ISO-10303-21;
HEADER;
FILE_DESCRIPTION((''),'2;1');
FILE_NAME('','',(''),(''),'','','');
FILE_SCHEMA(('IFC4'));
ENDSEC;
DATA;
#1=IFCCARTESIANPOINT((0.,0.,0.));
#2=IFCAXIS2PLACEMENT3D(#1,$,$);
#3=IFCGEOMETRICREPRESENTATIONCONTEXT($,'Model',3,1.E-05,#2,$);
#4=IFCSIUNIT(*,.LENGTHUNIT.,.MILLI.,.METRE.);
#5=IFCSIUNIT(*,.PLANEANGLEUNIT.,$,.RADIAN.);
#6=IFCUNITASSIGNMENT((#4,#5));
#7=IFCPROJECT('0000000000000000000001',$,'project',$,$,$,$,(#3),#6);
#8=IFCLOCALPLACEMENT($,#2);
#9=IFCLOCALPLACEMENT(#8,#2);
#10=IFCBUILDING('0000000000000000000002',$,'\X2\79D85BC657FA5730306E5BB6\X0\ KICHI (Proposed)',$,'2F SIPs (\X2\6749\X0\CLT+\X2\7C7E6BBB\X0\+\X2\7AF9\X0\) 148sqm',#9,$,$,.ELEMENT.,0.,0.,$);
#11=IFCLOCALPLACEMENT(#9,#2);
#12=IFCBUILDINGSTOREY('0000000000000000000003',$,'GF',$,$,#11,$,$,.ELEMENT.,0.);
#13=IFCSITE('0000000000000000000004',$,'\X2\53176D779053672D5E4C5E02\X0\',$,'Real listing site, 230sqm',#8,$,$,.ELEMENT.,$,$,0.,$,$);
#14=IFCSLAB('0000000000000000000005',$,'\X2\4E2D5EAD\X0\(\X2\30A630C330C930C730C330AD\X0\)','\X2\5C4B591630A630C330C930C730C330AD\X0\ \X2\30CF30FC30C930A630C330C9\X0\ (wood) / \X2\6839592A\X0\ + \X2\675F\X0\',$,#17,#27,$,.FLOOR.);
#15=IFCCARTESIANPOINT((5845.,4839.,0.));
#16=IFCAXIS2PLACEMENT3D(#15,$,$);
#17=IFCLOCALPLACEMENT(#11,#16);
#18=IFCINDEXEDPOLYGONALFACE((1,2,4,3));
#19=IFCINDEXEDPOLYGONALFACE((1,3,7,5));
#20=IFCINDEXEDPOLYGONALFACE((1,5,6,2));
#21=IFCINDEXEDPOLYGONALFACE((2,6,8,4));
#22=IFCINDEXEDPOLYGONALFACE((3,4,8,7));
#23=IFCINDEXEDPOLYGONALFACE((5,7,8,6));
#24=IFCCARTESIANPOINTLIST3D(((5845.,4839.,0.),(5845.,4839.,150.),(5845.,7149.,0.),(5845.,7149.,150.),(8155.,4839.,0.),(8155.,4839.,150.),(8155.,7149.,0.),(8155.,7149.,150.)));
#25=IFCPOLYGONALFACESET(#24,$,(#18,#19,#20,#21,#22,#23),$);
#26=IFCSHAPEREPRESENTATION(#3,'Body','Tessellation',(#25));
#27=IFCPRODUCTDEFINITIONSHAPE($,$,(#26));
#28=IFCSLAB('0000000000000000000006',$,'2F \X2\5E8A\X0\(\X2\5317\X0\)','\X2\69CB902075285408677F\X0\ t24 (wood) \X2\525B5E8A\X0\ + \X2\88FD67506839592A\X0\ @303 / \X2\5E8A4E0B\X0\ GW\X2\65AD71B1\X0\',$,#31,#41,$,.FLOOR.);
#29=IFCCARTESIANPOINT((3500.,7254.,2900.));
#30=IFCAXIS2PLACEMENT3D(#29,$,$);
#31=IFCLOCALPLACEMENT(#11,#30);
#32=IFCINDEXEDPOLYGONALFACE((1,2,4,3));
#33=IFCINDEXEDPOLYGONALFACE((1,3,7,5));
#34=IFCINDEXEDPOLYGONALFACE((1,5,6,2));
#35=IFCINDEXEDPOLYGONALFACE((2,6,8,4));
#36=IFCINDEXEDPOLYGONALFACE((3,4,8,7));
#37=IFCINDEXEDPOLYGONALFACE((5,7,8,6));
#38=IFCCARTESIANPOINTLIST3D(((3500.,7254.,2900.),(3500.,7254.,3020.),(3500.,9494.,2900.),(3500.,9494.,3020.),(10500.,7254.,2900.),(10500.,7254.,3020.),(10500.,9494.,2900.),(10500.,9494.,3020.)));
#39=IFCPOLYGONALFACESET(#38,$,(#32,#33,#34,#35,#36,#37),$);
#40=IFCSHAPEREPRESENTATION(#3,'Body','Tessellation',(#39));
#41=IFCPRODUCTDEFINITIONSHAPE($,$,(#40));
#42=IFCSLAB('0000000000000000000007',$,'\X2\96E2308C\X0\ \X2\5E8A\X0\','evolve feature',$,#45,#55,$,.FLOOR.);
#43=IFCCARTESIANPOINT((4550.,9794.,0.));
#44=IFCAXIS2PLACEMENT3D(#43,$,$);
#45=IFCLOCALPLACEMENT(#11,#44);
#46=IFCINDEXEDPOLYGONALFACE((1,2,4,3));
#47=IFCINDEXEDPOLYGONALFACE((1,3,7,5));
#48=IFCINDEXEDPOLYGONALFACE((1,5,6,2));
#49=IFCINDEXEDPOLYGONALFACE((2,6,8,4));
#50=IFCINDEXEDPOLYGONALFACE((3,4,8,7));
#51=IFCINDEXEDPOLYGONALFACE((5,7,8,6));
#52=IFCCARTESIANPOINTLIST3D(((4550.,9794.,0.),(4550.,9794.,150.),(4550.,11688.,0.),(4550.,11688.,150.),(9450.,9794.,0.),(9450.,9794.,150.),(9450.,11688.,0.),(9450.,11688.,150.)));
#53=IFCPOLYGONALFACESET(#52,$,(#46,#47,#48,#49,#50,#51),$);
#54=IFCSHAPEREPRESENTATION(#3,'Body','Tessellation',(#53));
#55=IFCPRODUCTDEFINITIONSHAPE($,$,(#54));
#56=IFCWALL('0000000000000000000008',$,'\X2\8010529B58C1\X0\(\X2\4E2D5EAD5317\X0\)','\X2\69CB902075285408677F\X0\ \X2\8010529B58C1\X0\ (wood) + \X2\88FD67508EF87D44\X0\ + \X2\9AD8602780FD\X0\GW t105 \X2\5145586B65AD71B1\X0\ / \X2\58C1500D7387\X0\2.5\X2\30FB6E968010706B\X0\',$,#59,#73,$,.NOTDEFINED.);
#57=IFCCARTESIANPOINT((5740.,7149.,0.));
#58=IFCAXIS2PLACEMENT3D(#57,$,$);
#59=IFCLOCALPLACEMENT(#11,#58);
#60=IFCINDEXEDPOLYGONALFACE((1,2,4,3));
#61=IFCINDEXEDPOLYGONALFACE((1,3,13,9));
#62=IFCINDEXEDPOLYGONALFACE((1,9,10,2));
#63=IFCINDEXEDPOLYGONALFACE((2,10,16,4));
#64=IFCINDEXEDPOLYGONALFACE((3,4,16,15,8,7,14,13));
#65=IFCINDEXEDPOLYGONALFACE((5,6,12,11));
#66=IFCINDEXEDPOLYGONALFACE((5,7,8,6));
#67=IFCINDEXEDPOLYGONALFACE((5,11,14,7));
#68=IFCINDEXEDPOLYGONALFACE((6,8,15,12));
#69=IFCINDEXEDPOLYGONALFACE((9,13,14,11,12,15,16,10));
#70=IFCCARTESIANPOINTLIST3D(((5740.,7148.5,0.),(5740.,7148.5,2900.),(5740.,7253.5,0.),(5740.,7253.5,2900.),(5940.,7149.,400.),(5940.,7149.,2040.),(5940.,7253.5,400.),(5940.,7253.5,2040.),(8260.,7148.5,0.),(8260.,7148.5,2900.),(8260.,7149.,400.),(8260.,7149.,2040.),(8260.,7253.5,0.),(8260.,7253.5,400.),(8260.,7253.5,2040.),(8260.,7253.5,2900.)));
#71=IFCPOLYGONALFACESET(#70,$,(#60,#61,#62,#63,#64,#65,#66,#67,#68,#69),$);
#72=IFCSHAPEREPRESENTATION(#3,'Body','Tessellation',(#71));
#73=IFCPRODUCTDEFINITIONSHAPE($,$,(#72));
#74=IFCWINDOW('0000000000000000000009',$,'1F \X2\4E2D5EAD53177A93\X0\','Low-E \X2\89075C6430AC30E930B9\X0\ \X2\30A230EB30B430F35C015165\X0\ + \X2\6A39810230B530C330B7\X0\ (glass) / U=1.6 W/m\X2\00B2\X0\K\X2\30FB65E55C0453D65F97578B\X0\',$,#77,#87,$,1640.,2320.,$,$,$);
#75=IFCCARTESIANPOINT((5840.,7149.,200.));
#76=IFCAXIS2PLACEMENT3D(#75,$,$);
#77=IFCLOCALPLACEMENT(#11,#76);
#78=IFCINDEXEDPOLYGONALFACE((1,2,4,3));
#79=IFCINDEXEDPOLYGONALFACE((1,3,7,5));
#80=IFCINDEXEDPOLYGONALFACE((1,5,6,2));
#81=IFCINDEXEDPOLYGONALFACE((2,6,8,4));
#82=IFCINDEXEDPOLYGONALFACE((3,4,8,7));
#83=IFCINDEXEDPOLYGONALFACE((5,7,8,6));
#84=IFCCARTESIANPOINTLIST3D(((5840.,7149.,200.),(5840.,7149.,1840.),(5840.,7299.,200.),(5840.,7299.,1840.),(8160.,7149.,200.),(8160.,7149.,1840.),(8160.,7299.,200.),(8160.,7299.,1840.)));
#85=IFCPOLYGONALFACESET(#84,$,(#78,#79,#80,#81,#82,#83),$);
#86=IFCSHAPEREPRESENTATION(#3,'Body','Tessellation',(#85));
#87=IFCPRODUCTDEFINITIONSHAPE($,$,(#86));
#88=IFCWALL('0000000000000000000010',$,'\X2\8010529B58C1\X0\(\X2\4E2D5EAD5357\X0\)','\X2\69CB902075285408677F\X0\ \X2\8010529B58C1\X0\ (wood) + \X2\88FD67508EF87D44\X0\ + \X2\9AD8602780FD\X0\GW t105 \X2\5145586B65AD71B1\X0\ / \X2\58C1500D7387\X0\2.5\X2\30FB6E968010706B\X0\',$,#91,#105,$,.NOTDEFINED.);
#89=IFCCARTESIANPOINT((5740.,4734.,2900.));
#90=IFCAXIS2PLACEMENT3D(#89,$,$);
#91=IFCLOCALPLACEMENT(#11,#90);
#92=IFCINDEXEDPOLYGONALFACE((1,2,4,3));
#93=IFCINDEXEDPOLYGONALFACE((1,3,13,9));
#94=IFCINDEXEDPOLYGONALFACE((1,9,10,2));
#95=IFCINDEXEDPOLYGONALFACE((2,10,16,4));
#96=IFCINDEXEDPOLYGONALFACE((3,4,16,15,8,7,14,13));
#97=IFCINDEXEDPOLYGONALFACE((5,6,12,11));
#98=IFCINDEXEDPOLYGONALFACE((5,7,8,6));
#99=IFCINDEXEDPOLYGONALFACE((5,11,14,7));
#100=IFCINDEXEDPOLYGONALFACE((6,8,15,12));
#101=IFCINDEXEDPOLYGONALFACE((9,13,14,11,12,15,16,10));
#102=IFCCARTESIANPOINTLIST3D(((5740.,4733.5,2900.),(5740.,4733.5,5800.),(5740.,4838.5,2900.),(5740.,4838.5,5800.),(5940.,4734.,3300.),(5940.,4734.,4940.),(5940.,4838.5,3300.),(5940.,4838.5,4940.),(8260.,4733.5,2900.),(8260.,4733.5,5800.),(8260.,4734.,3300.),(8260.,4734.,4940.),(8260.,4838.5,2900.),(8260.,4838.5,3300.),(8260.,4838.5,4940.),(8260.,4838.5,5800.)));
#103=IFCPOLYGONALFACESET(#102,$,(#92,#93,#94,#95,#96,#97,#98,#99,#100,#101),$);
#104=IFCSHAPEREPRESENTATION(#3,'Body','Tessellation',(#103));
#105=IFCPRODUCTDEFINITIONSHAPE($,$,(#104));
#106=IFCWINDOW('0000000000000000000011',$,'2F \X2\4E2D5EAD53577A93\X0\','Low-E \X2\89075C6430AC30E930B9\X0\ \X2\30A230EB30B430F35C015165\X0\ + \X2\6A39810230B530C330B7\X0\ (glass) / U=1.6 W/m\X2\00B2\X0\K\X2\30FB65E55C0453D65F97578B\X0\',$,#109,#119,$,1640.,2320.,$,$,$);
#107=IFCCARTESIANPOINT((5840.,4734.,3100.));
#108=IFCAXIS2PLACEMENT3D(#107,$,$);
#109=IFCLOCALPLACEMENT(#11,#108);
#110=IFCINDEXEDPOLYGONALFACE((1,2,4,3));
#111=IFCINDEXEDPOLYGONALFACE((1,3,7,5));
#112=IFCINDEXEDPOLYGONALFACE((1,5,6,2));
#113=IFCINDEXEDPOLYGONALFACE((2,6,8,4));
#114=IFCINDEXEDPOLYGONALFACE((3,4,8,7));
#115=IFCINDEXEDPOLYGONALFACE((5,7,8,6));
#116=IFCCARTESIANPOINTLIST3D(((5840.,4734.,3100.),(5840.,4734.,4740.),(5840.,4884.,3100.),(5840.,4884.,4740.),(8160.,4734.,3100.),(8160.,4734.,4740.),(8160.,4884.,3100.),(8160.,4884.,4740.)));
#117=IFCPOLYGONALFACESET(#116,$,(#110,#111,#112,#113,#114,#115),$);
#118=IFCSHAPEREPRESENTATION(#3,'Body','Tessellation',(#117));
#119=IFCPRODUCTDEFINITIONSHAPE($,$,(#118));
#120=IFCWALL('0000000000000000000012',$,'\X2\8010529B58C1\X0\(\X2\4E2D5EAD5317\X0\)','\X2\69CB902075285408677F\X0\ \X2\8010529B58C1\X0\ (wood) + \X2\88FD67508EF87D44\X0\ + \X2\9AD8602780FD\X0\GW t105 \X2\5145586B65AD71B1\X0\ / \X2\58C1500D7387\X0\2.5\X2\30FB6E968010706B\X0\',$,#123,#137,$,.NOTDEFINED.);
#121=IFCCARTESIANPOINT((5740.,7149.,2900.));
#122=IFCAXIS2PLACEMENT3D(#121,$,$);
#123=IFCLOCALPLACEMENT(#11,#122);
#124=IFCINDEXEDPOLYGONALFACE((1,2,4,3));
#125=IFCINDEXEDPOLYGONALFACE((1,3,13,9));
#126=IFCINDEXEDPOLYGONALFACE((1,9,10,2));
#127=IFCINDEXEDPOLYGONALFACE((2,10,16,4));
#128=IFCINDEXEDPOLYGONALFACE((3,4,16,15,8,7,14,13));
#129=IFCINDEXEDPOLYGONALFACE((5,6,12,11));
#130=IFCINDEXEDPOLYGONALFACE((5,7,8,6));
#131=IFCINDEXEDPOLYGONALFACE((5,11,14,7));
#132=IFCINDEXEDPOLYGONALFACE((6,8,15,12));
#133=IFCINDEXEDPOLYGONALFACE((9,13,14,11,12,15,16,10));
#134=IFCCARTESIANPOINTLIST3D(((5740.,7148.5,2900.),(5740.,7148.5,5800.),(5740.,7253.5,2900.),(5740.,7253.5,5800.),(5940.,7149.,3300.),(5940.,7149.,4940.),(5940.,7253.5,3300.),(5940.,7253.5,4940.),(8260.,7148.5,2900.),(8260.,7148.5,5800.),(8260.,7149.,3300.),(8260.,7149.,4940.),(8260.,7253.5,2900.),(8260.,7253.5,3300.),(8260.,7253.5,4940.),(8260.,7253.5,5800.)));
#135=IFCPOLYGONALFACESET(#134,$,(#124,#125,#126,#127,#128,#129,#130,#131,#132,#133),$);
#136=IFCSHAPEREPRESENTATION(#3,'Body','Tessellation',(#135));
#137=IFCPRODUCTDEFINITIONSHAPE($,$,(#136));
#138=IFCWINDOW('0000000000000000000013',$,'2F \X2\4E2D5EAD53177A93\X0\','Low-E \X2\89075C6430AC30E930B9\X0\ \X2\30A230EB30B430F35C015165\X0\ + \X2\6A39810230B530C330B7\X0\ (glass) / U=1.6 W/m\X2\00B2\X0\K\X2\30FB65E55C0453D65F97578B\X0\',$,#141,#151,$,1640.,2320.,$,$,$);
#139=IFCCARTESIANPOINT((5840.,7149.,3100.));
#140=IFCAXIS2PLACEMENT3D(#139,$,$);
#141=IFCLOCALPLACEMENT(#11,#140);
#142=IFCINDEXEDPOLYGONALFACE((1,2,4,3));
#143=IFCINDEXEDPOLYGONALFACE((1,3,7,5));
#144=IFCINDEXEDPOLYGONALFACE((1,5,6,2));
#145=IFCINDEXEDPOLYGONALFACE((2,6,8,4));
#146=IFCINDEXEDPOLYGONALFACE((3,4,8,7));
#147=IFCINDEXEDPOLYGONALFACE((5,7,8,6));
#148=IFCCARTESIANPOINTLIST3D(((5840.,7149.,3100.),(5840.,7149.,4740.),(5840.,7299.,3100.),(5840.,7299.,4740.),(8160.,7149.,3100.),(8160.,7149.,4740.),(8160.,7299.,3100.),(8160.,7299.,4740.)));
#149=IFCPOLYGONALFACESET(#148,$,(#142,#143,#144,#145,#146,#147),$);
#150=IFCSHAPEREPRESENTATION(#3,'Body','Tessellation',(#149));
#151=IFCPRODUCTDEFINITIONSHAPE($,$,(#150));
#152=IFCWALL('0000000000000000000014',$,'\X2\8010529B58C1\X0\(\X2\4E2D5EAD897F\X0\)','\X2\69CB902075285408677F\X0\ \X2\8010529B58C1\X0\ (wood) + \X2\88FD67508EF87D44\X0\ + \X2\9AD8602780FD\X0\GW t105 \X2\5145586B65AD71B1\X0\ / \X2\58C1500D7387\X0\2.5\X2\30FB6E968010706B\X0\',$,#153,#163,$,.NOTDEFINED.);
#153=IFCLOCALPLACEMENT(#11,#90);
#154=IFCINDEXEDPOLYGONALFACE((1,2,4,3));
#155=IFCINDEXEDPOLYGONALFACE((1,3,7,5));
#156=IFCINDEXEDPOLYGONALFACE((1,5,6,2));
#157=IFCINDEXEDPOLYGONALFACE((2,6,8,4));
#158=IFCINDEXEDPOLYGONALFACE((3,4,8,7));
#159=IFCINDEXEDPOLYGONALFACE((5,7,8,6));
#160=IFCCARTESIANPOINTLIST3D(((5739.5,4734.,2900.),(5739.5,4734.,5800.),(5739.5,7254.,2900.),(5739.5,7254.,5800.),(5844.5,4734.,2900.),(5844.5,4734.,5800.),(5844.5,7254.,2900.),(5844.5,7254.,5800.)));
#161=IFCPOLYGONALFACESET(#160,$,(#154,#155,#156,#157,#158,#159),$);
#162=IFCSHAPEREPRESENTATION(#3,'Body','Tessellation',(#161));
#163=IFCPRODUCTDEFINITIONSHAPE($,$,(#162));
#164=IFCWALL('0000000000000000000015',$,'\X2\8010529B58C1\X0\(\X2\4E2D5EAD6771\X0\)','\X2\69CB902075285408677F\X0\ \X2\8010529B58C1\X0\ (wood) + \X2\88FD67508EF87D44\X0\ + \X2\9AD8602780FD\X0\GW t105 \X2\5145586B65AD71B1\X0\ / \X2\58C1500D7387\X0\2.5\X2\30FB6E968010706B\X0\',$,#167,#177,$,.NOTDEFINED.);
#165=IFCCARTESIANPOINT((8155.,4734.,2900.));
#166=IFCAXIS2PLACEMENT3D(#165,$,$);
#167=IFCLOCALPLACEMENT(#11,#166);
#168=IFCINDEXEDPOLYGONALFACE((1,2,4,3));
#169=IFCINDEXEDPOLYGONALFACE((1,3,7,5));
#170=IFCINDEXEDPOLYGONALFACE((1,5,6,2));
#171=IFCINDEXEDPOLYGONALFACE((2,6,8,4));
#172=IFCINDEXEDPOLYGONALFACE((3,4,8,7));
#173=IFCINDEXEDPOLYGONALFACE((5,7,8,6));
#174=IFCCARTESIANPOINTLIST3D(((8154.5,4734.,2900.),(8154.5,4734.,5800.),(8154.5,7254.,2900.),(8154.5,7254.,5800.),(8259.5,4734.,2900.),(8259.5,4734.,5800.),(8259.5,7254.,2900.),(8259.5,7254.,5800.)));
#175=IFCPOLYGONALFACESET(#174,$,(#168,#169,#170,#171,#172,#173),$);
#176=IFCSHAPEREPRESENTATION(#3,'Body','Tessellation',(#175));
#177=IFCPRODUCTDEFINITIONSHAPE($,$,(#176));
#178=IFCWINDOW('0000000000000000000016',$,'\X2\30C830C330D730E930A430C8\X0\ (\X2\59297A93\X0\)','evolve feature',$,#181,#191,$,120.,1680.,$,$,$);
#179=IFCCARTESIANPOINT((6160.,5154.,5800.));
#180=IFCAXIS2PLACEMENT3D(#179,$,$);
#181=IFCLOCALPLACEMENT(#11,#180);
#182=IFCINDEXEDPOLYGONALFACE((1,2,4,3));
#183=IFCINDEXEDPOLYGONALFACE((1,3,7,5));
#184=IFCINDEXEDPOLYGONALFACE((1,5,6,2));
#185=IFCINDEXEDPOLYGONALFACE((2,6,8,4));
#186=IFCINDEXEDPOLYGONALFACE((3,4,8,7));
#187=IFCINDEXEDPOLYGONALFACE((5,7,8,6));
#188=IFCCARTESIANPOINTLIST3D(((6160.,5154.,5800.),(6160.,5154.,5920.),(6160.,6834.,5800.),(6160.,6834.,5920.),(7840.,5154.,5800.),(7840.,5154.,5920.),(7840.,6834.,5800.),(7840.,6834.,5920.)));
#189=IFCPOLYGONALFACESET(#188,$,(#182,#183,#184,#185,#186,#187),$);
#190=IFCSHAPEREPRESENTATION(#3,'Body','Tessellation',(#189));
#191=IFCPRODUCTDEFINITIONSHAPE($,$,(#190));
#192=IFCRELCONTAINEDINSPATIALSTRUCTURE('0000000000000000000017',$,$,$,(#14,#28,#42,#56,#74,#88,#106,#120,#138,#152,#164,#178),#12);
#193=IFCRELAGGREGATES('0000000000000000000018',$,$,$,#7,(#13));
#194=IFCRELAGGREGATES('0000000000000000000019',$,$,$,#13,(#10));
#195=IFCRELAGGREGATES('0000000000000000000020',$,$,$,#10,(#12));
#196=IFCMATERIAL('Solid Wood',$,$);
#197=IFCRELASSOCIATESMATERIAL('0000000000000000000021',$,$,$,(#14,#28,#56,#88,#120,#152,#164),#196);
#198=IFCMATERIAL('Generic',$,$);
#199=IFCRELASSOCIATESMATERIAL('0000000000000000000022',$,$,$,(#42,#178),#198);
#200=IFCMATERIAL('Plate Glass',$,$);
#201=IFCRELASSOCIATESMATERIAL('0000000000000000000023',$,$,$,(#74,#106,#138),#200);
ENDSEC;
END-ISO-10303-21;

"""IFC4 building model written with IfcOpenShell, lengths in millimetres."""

from ifc_helpers import new_model, si_unit, frame, frame_2d, origin, place, context, project, spatial, rectangle, extrude, material, element, fill, save


model = new_model("IFC4")

# Units and contexts
model_context = context("Model", 3, precision=1e-05, world=origin())
ifc_project = project(units=[si_unit("LENGTHUNIT", "METRE", prefix="MILLI"), si_unit("PLANEANGLEUNIT", "RADIAN")], contexts=[model_context])

# Site, building, storey
site_placement = place(None, origin())
site = spatial("IfcSite", under=ifc_project, at=site_placement, Name="北海道札幌市", ObjectType="Real listing site, 230sqm", CompositionType="ELEMENT", RefElevation=0.0)
building_placement = place(site_placement, origin())
building = spatial("IfcBuilding", under=site, at=building_placement, Name="秘密基地の家 KICHI (Proposed)", ObjectType="2F SIPs (杉CLT+籾殻+竹) 148sqm", CompositionType="ELEMENT", ElevationOfRefHeight=0.0, ElevationOfTerrain=0.0)
storey_placement = place(building_placement, origin())
storey = spatial("IfcBuildingStorey", under=building, at=storey_placement, Name="GF", CompositionType="ELEMENT", Elevation=0.0)

# Slabs
ifc_material_1 = material(Name="Solid Wood")
slab_1_placement = place(storey_placement, frame((5845.0, 4839.0, 0.0)))
element("IfcSlab", 1, at=slab_1_placement, inside=storey, material=ifc_material_1, Name="中庭(ウッドデッキ)", Description="屋外ウッドデッキ ハードウッド (wood) / 根太 + 束", PredefinedType="FLOOR", context=model_context, shape_type="SweptSolid", body=[
    extrude(rectangle(XDim=2310.0, YDim=2310.0, at=frame_2d((1155.0, 1155.0))), frame((5845.0, 4839.0, 0.0)), (0.0, 0.0, 1.0), 150.0),
])
slab_2_placement = place(storey_placement, frame((3500.0, 7254.0, 2900.0)))
element("IfcSlab", 2, at=slab_2_placement, inside=storey, material=ifc_material_1, Name="2F 床(北)", Description="構造用合板 t24 (wood) 剛床 + 製材根太 @303 / 床下 GW断熱", PredefinedType="FLOOR", context=model_context, shape_type="SweptSolid", body=[
    extrude(rectangle(XDim=7000.0, YDim=2240.0, at=frame_2d((3500.0, 1120.0))), frame((3500.0, 7254.0, 2900.0)), (0.0, 0.0, 1.0), 120.0),
])
ifc_material_2 = material(Name="Generic")
slab_3_placement = place(storey_placement, frame((4550.0, 9794.0, 0.0)))
element("IfcSlab", 3, at=slab_3_placement, inside=storey, material=ifc_material_2, Name="離れ 床", Description="evolve feature", PredefinedType="FLOOR", context=model_context, shape_type="SweptSolid", body=[
    extrude(rectangle(XDim=4900.0, YDim=1894.0, at=frame_2d((2450.0, 947.0))), frame((4550.0, 9794.0, 0.0)), (0.0, 0.0, 1.0), 150.0),
])

# Wall, opening, window
wall_1_placement = place(storey_placement, frame((5740.0, 7149.0, 0.0)))
wall_1 = element("IfcWall", 4, at=wall_1_placement, inside=storey, material=ifc_material_1, Name="耐力壁(中庭北)", Description="構造用合板 耐力壁 (wood) + 製材軸組 + 高性能GW t105 充填断熱 / 壁倍率2.5・準耐火", PredefinedType="NOTDEFINED", context=model_context, shape_type="SweptSolid", body=[
    extrude(rectangle(XDim=2520.0, YDim=105.0, at=frame_2d((1260.0, 52.0))), frame((5740.0, 7149.0, 0.0)), (0.0, 0.0, 1.0), 2900.0),
])
opening_1_placement = place(storey_placement, frame((5840.0, 7149.0, 200.0)))
opening_1 = element("IfcOpeningElement", 5, at=opening_1_placement, cuts=wall_1, PredefinedType="NOTDEFINED", context=model_context, shape_type="SweptSolid", body=[
    extrude(rectangle(XDim=2320.0, YDim=150.0, at=frame_2d((1160.0, 75.0))), frame((5840.0, 7149.0, 200.0)), (0.0, 0.0, 1.0), 1640.0),
])
ifc_material_3 = material(Name="Plate Glass")
window_1_placement = place(storey_placement, frame((5840.0, 7149.0, 200.0)))
window_1 = element("IfcWindow", 6, at=window_1_placement, inside=storey, material=ifc_material_3, Name="1F 中庭北窓", Description="Low-E 複層ガラス アルゴン封入 + 樹脂サッシ (glass) / U=1.6 W/m²K・日射取得型", OverallHeight=1640.0, OverallWidth=2320.0, context=model_context, shape_type="SweptSolid", body=[
    extrude(rectangle(XDim=2320.0, YDim=150.0, at=frame_2d((1160.0, 75.0))), frame((5840.0, 7149.0, 200.0)), (0.0, 0.0, 1.0), 1640.0),
])
fill(opening_1, window_1)

# Walls, openings, windows
wall_2_placement = place(storey_placement, frame((5740.0, 4734.0, 2900.0)))
wall_2 = element("IfcWall", 7, at=wall_2_placement, inside=storey, material=ifc_material_1, Name="耐力壁(中庭南)", Description="構造用合板 耐力壁 (wood) + 製材軸組 + 高性能GW t105 充填断熱 / 壁倍率2.5・準耐火", PredefinedType="NOTDEFINED", context=model_context, shape_type="SweptSolid", body=[
    extrude(rectangle(XDim=2520.0, YDim=105.0, at=frame_2d((1260.0, 52.0))), frame((5740.0, 4734.0, 2900.0)), (0.0, 0.0, 1.0), 2900.0),
])
opening_2_placement = place(storey_placement, frame((5840.0, 4734.0, 3100.0)))
opening_2 = element("IfcOpeningElement", 8, at=opening_2_placement, cuts=wall_2, PredefinedType="NOTDEFINED", context=model_context, shape_type="SweptSolid", body=[
    extrude(rectangle(XDim=2320.0, YDim=150.0, at=frame_2d((1160.0, 75.0))), frame((5840.0, 4734.0, 3100.0)), (0.0, 0.0, 1.0), 1640.0),
])
window_2_placement = place(storey_placement, frame((5840.0, 4734.0, 3100.0)))
window_2 = element("IfcWindow", 9, at=window_2_placement, inside=storey, material=ifc_material_3, Name="2F 中庭南窓", Description="Low-E 複層ガラス アルゴン封入 + 樹脂サッシ (glass) / U=1.6 W/m²K・日射取得型", OverallHeight=1640.0, OverallWidth=2320.0, context=model_context, shape_type="SweptSolid", body=[
    extrude(rectangle(XDim=2320.0, YDim=150.0, at=frame_2d((1160.0, 75.0))), frame((5840.0, 4734.0, 3100.0)), (0.0, 0.0, 1.0), 1640.0),
])
fill(opening_2, window_2)
wall_3_placement = place(storey_placement, frame((5740.0, 7149.0, 2900.0)))
wall_3 = element("IfcWall", 10, at=wall_3_placement, inside=storey, material=ifc_material_1, Name="耐力壁(中庭北)", Description="構造用合板 耐力壁 (wood) + 製材軸組 + 高性能GW t105 充填断熱 / 壁倍率2.5・準耐火", PredefinedType="NOTDEFINED", context=model_context, shape_type="SweptSolid", body=[
    extrude(rectangle(XDim=2520.0, YDim=105.0, at=frame_2d((1260.0, 52.0))), frame((5740.0, 7149.0, 2900.0)), (0.0, 0.0, 1.0), 2900.0),
])
opening_3_placement = place(storey_placement, frame((5840.0, 7149.0, 3100.0)))
opening_3 = element("IfcOpeningElement", 11, at=opening_3_placement, cuts=wall_3, PredefinedType="NOTDEFINED", context=model_context, shape_type="SweptSolid", body=[
    extrude(rectangle(XDim=2320.0, YDim=150.0, at=frame_2d((1160.0, 75.0))), frame((5840.0, 7149.0, 3100.0)), (0.0, 0.0, 1.0), 1640.0),
])
window_3_placement = place(storey_placement, frame((5840.0, 7149.0, 3100.0)))
window_3 = element("IfcWindow", 12, at=window_3_placement, inside=storey, material=ifc_material_3, Name="2F 中庭北窓", Description="Low-E 複層ガラス アルゴン封入 + 樹脂サッシ (glass) / U=1.6 W/m²K・日射取得型", OverallHeight=1640.0, OverallWidth=2320.0, context=model_context, shape_type="SweptSolid", body=[
    extrude(rectangle(XDim=2320.0, YDim=150.0, at=frame_2d((1160.0, 75.0))), frame((5840.0, 7149.0, 3100.0)), (0.0, 0.0, 1.0), 1640.0),
])
fill(opening_3, window_3)

# Walls
wall_4_placement = place(storey_placement, frame((5740.0, 4734.0, 2900.0)))
element("IfcWall", 13, at=wall_4_placement, inside=storey, material=ifc_material_1, Name="耐力壁(中庭西)", Description="構造用合板 耐力壁 (wood) + 製材軸組 + 高性能GW t105 充填断熱 / 壁倍率2.5・準耐火", PredefinedType="NOTDEFINED", context=model_context, shape_type="SweptSolid", body=[
    extrude(rectangle(XDim=105.0, YDim=2520.0, at=frame_2d((52.0, 1260.0))), frame((5740.0, 4734.0, 2900.0)), (0.0, 0.0, 1.0), 2900.0),
])
wall_5_placement = place(storey_placement, frame((8155.0, 4734.0, 2900.0)))
element("IfcWall", 14, at=wall_5_placement, inside=storey, material=ifc_material_1, Name="耐力壁(中庭東)", Description="構造用合板 耐力壁 (wood) + 製材軸組 + 高性能GW t105 充填断熱 / 壁倍率2.5・準耐火", PredefinedType="NOTDEFINED", context=model_context, shape_type="SweptSolid", body=[
    extrude(rectangle(XDim=105.0, YDim=2520.0, at=frame_2d((52.0, 1260.0))), frame((8155.0, 4734.0, 2900.0)), (0.0, 0.0, 1.0), 2900.0),
])

# Window
window_4_placement = place(storey_placement, frame((6160.0, 5154.0, 5800.0)))
element("IfcWindow", 15, at=window_4_placement, inside=storey, material=ifc_material_2, Name="トップライト (天窓)", Description="evolve feature", OverallHeight=120.0, OverallWidth=1680.0, context=model_context, shape_type="SweptSolid", body=[
    extrude(rectangle(XDim=1680.0, YDim=1680.0, at=frame_2d((840.0, 840.0))), frame((6160.0, 5154.0, 5800.0)), (0.0, 0.0, 1.0), 120.0),
])

save(model, "model.ifc")
